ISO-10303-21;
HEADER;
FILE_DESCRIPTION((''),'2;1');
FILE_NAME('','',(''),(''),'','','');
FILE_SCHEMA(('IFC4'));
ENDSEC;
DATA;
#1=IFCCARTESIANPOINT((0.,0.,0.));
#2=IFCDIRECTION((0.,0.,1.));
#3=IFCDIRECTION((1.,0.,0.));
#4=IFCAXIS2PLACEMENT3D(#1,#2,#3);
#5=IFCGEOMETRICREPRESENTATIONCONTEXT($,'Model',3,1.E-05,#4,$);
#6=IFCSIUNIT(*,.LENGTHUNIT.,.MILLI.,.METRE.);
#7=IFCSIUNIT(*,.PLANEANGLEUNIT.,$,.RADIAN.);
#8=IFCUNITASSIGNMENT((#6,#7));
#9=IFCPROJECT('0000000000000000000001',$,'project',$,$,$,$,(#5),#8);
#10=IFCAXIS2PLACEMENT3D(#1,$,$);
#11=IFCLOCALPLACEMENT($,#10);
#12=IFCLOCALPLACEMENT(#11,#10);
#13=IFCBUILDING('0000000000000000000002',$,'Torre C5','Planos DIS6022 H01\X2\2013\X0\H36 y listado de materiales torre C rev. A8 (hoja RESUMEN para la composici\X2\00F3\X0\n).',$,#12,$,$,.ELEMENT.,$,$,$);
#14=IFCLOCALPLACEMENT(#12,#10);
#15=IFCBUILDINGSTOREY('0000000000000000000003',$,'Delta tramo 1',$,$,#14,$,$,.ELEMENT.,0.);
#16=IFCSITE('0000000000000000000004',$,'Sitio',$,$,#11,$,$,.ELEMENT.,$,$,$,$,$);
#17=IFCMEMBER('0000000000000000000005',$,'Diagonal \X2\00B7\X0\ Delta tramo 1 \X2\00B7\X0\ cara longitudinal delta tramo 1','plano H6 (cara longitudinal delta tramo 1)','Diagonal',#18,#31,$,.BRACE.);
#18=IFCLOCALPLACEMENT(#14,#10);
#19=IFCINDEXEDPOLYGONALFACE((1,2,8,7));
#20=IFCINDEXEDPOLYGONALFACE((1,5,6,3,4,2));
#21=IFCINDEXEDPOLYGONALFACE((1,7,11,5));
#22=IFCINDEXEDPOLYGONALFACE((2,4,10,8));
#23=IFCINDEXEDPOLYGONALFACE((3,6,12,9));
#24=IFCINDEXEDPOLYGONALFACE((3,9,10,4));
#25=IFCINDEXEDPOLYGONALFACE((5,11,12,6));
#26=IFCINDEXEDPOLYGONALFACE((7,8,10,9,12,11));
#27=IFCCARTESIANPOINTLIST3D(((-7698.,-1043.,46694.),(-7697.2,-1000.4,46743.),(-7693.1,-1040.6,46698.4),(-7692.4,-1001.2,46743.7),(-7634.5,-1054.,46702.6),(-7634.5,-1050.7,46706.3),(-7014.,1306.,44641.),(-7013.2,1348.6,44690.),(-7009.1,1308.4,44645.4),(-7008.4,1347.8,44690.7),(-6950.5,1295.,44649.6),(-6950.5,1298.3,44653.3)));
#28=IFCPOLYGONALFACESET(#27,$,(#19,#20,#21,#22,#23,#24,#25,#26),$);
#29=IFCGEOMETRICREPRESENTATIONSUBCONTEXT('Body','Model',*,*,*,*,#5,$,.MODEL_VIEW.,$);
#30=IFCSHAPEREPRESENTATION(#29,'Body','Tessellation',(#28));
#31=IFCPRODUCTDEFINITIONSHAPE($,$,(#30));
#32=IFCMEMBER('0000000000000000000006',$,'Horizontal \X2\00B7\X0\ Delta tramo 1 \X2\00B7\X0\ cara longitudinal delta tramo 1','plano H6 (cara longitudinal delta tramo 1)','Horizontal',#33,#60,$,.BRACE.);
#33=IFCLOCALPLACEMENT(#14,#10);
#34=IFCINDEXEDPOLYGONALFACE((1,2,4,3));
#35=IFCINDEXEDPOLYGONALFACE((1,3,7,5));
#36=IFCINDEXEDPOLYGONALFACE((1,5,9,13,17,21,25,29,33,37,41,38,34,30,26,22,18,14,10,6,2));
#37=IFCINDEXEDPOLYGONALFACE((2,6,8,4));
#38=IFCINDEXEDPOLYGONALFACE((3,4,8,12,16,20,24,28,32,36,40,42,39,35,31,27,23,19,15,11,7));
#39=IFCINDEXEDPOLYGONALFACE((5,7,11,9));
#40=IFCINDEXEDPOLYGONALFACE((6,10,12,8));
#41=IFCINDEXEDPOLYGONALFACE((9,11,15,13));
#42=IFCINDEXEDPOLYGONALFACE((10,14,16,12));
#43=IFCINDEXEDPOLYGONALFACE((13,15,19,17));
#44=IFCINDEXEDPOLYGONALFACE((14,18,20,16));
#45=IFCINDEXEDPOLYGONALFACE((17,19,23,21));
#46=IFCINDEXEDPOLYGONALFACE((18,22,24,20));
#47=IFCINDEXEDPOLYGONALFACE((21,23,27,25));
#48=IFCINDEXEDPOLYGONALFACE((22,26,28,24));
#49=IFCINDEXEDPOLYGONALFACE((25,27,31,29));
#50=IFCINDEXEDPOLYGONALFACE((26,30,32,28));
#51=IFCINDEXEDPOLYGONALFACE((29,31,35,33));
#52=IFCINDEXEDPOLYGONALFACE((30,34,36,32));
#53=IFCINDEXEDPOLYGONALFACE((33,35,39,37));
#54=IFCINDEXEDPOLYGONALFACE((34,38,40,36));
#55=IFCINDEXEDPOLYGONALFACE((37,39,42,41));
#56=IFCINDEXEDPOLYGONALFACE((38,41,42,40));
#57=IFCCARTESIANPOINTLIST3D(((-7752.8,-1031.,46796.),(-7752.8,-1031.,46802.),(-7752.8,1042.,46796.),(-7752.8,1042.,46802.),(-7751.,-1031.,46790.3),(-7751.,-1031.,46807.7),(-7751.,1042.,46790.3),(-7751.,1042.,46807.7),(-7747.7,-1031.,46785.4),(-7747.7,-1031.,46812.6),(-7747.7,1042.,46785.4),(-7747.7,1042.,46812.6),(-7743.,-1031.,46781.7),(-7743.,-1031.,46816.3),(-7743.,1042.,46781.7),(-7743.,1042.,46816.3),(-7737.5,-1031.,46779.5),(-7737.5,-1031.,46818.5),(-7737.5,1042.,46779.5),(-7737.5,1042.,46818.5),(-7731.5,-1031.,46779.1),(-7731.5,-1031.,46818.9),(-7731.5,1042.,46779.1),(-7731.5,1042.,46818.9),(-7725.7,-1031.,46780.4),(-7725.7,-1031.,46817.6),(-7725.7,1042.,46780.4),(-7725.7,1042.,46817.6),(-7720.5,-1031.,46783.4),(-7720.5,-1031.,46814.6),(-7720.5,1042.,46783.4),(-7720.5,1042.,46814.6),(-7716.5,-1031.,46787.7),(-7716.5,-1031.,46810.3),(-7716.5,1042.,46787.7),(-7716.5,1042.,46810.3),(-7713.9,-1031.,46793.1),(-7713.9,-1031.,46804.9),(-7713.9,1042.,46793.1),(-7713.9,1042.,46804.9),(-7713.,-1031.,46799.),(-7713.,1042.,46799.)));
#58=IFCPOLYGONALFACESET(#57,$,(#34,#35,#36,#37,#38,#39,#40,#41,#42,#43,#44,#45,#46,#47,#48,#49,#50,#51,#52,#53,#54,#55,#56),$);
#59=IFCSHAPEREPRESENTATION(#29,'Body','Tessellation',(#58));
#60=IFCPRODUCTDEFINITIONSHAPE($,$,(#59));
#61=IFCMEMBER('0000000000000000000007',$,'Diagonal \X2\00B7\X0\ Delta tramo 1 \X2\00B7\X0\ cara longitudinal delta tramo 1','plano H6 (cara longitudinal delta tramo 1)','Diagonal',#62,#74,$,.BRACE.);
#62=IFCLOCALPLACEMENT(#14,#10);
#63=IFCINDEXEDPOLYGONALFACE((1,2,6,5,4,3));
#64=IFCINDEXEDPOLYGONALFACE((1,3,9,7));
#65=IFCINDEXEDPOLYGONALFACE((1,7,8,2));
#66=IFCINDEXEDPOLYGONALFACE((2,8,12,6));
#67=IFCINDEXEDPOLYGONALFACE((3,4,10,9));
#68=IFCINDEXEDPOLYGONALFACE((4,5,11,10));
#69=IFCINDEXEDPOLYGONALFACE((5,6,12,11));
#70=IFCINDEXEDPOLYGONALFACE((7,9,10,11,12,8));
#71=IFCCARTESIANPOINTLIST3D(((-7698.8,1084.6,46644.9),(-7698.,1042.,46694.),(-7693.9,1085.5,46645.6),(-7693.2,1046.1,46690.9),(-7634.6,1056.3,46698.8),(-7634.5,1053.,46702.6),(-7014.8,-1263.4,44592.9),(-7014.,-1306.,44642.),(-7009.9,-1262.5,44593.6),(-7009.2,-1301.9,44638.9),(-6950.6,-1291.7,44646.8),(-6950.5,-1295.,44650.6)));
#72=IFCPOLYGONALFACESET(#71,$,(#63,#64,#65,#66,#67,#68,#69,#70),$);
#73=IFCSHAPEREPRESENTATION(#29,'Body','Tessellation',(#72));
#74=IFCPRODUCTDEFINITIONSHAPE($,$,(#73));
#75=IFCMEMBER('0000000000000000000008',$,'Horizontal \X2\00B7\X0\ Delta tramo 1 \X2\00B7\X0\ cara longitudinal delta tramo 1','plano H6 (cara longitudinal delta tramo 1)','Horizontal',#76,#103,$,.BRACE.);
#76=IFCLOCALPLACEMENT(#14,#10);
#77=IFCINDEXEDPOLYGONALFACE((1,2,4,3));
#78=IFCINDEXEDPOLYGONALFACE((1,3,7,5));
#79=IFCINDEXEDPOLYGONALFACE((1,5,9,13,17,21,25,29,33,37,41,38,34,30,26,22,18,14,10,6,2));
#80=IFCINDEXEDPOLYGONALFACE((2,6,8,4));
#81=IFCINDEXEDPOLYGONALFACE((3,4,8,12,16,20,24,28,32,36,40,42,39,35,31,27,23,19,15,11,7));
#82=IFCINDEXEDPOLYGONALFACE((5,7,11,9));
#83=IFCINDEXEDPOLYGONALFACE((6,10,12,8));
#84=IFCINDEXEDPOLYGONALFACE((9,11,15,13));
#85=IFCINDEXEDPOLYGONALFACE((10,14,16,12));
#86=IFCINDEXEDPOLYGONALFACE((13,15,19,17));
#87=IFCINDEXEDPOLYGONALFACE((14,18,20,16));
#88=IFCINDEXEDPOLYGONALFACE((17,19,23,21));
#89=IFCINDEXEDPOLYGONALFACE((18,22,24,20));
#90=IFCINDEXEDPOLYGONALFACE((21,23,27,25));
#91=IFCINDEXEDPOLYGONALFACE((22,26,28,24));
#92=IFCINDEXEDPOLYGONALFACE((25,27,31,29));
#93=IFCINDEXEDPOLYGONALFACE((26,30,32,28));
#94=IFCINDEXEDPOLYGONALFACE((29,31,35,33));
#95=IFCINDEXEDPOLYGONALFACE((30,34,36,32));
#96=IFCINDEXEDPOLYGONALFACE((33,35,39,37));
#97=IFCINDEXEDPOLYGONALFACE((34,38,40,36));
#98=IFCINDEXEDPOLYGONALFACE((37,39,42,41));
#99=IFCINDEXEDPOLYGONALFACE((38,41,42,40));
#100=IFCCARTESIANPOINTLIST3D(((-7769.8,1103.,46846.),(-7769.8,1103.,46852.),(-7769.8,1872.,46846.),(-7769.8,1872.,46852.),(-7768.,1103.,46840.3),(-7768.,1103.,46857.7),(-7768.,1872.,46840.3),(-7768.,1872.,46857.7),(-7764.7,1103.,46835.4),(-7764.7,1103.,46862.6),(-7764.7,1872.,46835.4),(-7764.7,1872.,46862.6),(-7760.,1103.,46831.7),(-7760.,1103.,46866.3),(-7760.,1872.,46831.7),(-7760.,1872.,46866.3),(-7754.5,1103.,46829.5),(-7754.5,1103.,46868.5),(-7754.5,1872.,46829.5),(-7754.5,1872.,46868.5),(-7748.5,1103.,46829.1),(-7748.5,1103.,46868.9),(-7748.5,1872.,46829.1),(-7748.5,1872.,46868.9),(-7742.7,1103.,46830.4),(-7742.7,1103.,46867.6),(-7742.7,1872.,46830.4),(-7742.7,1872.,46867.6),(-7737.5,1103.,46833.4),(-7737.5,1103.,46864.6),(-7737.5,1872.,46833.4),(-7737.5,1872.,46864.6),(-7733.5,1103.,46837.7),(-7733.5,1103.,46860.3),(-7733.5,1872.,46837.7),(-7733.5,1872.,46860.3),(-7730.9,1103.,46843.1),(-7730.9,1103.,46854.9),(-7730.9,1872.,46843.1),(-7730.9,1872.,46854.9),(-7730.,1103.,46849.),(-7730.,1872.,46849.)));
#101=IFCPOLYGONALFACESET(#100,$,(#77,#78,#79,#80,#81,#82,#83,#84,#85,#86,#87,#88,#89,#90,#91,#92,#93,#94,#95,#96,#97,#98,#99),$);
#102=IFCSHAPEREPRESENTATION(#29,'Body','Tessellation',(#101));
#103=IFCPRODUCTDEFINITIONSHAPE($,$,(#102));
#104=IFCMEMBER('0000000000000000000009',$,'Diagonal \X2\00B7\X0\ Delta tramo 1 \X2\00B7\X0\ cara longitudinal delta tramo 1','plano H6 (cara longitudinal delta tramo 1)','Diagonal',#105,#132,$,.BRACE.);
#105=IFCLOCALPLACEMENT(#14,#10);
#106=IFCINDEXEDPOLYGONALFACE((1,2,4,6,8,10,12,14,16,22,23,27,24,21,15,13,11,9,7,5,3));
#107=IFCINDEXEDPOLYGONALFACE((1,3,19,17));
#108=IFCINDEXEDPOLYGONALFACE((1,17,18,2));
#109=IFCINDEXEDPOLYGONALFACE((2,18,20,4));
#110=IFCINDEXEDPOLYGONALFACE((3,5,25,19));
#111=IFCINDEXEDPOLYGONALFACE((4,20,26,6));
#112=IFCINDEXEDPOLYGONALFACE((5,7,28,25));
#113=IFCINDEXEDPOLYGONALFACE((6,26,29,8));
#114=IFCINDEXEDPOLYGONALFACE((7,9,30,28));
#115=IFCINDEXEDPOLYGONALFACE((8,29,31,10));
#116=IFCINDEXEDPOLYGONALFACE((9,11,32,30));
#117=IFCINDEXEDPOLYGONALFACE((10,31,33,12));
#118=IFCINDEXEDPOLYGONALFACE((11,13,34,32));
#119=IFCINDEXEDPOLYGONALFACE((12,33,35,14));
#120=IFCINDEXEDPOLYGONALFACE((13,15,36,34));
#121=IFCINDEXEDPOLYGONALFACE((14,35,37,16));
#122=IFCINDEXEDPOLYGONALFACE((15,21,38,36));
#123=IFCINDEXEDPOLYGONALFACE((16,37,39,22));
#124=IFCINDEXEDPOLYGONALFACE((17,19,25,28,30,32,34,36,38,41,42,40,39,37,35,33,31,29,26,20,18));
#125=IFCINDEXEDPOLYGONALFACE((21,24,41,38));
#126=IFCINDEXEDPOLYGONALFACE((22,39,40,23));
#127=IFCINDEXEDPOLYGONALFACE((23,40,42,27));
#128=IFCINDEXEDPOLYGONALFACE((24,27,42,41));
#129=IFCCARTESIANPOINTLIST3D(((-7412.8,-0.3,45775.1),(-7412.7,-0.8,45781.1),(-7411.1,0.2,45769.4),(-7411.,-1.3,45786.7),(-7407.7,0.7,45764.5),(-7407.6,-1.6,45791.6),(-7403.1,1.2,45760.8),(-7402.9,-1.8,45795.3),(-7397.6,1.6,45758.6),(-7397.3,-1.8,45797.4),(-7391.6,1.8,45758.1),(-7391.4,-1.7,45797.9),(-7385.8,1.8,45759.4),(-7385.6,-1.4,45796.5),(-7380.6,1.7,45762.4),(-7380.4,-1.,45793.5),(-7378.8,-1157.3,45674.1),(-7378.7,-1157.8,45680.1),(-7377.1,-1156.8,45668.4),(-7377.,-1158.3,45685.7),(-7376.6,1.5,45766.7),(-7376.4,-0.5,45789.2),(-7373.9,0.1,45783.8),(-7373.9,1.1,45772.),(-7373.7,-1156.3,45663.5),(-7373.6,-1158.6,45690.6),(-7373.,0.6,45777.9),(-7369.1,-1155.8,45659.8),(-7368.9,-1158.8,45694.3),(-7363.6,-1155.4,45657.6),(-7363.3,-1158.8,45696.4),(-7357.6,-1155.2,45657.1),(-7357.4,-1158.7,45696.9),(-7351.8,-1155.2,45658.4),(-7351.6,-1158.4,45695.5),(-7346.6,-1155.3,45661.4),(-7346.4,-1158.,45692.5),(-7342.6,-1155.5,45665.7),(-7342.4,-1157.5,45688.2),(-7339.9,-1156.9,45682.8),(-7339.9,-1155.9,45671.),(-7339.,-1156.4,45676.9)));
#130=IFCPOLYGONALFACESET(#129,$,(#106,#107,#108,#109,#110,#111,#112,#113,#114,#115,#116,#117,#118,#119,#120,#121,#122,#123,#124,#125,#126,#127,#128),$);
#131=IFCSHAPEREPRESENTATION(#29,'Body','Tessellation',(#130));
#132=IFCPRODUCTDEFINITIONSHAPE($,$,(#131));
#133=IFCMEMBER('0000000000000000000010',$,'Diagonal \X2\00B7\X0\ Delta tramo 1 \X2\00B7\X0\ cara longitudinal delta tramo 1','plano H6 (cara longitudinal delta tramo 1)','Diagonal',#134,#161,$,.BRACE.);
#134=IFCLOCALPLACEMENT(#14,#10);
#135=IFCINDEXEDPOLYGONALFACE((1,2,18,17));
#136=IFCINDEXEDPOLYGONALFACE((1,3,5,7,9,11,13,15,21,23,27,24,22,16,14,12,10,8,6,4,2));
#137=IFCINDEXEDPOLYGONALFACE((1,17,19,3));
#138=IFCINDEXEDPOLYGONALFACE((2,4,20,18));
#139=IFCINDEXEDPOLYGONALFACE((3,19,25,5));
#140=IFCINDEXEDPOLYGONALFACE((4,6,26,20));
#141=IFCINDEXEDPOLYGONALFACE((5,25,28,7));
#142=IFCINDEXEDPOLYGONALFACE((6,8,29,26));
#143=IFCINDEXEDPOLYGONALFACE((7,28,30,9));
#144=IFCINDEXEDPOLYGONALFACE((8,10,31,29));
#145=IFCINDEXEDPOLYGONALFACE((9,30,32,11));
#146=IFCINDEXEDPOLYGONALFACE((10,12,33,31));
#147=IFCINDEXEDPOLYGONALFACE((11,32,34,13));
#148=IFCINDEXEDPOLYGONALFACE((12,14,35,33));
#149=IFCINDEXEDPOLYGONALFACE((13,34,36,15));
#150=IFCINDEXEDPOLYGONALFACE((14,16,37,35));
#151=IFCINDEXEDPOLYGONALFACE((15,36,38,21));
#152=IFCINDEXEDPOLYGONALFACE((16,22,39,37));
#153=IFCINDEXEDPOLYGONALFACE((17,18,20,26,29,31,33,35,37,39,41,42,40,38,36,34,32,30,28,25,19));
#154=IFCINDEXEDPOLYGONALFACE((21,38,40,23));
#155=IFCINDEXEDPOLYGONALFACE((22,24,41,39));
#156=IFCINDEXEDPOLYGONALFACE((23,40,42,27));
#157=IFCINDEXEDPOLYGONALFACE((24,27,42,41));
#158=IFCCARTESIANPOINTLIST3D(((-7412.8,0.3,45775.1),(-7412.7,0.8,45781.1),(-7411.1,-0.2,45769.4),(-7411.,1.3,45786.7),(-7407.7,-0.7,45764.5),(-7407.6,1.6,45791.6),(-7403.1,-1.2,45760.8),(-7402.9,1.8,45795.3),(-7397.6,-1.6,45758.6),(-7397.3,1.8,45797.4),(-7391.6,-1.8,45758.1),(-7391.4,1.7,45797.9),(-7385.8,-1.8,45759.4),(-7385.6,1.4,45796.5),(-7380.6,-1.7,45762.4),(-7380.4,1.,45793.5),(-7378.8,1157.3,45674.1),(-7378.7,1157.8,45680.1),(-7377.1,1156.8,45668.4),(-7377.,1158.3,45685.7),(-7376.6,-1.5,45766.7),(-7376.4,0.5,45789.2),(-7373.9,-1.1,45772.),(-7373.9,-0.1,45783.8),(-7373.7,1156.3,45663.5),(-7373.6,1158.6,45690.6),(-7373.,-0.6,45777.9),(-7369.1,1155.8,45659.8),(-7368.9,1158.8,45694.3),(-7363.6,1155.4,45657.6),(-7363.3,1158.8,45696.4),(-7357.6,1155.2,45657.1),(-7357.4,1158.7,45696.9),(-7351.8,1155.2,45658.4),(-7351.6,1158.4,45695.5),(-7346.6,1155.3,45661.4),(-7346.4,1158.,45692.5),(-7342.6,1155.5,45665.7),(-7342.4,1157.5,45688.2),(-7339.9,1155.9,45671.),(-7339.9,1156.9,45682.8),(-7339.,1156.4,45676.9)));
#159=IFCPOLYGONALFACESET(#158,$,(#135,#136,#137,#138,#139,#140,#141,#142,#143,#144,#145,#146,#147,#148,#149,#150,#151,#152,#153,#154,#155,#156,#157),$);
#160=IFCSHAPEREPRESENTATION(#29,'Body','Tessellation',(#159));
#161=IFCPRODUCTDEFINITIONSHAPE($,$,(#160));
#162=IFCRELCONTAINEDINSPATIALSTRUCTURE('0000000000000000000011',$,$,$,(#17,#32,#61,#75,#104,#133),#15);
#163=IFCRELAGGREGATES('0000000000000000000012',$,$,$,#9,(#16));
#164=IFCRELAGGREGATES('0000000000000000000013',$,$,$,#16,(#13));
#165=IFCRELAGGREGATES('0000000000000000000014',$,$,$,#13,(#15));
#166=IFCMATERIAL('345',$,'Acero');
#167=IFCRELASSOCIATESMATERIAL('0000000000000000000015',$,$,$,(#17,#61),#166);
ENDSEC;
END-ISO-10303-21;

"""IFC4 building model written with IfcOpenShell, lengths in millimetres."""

from ifc_helpers import new_model, si_unit, frame, frame_2d, origin, origin_with_axes, place, context, subcontext, project, spatial, circle, l_section, extrude, material, element, save


model = new_model("IFC4")

# Units and contexts
model_context = context("Model", 3, precision=1e-05, world=origin_with_axes())
body_context = subcontext(model_context, "Body", "Model", "MODEL_VIEW")
ifc_project = project(units=[si_unit("LENGTHUNIT", "METRE", prefix="MILLI"), si_unit("PLANEANGLEUNIT", "RADIAN")], contexts=[model_context])

# Site, building, storey
site_placement = place(None, origin())
site = spatial("IfcSite", under=ifc_project, at=site_placement, Name="Sitio", CompositionType="ELEMENT")
building_placement = place(site_placement, origin())
building = spatial("IfcBuilding", under=site, at=building_placement, Name="Torre C5", Description="Planos DIS6022 H01–H36 y listado de materiales torre C rev. A8 (hoja RESUMEN para la composición).", CompositionType="ELEMENT")
storey_placement = place(building_placement, origin())
storey = spatial("IfcBuildingStorey", under=building, at=storey_placement, Name="Delta tramo 1", CompositionType="ELEMENT", Elevation=0.0)

# Members
ifc_material = material(Name="345", Category="Acero")
member_1_placement = place(storey_placement, frame((-7014.0, 1306.0, 44641.0), z_axis=(-0.214164, -0.735484, 0.642805), x_axis=(0.976727, -0.169145, 0.131884)))
element("IfcMember", 1, at=member_1_placement, inside=storey, material=ifc_material, Name="Diagonal · Delta tramo 1 · cara longitudinal delta tramo 1", Description="plano H6 (cara longitudinal delta tramo 1)", ObjectType="Diagonal", PredefinedType="BRACE", context=body_context, shape_type="SweptSolid", body=[
    extrude(l_section(Depth=65.0, Width=65.0, Thickness=5.0, at=frame_2d((32.5, 32.5))), None, (0.0, 0.0, 1.0), 3193.8),
])
member_2_placement = place(storey_placement, frame((-7733.0, -1031.0, 46799.0), z_axis=(0.0, 1.0, 0.0), x_axis=(1.0, 0.0, 0.0)))
element("IfcMember", 2, at=member_2_placement, inside=storey, Name="Horizontal · Delta tramo 1 · cara longitudinal delta tramo 1", Description="plano H6 (cara longitudinal delta tramo 1)", ObjectType="Horizontal", PredefinedType="BRACE", context=body_context, shape_type="SweptSolid", body=[
    extrude(circle(Radius=20.0), None, (0.0, 0.0, 1.0), 2073.0),
])
member_3_placement = place(storey_placement, frame((-7014.0, -1306.0, 44642.0), z_axis=(-0.214256, 0.735488, 0.642769), x_axis=(0.976707, 0.169249, 0.131906)))
element("IfcMember", 3, at=member_3_placement, inside=storey, material=ifc_material, Name="Diagonal · Delta tramo 1 · cara longitudinal delta tramo 1", Description="plano H6 (cara longitudinal delta tramo 1)", ObjectType="Diagonal", PredefinedType="BRACE", context=body_context, shape_type="SweptSolid", body=[
    extrude(l_section(Depth=65.0, Width=65.0, Thickness=5.0, at=frame_2d((32.5, 32.5))), None, (0.0, 0.0, 1.0), 3192.4),
])
member_4_placement = place(storey_placement, frame((-7750.0, 1103.0, 46849.0), z_axis=(0.0, 1.0, 0.0), x_axis=(1.0, 0.0, 0.0)))
element("IfcMember", 4, at=member_4_placement, inside=storey, Name="Horizontal · Delta tramo 1 · cara longitudinal delta tramo 1", Description="plano H6 (cara longitudinal delta tramo 1)", ObjectType="Horizontal", PredefinedType="BRACE", context=body_context, shape_type="SweptSolid", body=[
    extrude(circle(Radius=20.0), None, (0.0, 0.0, 1.0), 769.0),
])
for number, where, z_axis, x_axis, name in (
    (5, (-7359.0, -1157.0, 45677.0), (-0.029262, 0.995785, 0.086927), (0.999549, 0.029743, -0.004237), "Diagonal · Delta tramo 1 · cara longitudinal delta tramo 1"),
    (6, (-7359.0, 1157.0, 45677.0), (-0.029262, -0.995785, 0.086927), (0.999549, -0.029743, -0.004237), "Diagonal · Delta tramo 1 · cara longitudinal delta tramo 1"),
):
    element("IfcMember", number, at=place(storey_placement, frame(where, z_axis=z_axis, x_axis=x_axis)), inside=storey, Name=name, Description="plano H6 (cara longitudinal delta tramo 1)", ObjectType="Diagonal", PredefinedType="BRACE", context=body_context, shape_type="SweptSolid", body=[
        extrude(circle(Radius=20.0), None, (0.0, 0.0, 1.0), 1161.9),
    ])

save(model, "model.ifc")
